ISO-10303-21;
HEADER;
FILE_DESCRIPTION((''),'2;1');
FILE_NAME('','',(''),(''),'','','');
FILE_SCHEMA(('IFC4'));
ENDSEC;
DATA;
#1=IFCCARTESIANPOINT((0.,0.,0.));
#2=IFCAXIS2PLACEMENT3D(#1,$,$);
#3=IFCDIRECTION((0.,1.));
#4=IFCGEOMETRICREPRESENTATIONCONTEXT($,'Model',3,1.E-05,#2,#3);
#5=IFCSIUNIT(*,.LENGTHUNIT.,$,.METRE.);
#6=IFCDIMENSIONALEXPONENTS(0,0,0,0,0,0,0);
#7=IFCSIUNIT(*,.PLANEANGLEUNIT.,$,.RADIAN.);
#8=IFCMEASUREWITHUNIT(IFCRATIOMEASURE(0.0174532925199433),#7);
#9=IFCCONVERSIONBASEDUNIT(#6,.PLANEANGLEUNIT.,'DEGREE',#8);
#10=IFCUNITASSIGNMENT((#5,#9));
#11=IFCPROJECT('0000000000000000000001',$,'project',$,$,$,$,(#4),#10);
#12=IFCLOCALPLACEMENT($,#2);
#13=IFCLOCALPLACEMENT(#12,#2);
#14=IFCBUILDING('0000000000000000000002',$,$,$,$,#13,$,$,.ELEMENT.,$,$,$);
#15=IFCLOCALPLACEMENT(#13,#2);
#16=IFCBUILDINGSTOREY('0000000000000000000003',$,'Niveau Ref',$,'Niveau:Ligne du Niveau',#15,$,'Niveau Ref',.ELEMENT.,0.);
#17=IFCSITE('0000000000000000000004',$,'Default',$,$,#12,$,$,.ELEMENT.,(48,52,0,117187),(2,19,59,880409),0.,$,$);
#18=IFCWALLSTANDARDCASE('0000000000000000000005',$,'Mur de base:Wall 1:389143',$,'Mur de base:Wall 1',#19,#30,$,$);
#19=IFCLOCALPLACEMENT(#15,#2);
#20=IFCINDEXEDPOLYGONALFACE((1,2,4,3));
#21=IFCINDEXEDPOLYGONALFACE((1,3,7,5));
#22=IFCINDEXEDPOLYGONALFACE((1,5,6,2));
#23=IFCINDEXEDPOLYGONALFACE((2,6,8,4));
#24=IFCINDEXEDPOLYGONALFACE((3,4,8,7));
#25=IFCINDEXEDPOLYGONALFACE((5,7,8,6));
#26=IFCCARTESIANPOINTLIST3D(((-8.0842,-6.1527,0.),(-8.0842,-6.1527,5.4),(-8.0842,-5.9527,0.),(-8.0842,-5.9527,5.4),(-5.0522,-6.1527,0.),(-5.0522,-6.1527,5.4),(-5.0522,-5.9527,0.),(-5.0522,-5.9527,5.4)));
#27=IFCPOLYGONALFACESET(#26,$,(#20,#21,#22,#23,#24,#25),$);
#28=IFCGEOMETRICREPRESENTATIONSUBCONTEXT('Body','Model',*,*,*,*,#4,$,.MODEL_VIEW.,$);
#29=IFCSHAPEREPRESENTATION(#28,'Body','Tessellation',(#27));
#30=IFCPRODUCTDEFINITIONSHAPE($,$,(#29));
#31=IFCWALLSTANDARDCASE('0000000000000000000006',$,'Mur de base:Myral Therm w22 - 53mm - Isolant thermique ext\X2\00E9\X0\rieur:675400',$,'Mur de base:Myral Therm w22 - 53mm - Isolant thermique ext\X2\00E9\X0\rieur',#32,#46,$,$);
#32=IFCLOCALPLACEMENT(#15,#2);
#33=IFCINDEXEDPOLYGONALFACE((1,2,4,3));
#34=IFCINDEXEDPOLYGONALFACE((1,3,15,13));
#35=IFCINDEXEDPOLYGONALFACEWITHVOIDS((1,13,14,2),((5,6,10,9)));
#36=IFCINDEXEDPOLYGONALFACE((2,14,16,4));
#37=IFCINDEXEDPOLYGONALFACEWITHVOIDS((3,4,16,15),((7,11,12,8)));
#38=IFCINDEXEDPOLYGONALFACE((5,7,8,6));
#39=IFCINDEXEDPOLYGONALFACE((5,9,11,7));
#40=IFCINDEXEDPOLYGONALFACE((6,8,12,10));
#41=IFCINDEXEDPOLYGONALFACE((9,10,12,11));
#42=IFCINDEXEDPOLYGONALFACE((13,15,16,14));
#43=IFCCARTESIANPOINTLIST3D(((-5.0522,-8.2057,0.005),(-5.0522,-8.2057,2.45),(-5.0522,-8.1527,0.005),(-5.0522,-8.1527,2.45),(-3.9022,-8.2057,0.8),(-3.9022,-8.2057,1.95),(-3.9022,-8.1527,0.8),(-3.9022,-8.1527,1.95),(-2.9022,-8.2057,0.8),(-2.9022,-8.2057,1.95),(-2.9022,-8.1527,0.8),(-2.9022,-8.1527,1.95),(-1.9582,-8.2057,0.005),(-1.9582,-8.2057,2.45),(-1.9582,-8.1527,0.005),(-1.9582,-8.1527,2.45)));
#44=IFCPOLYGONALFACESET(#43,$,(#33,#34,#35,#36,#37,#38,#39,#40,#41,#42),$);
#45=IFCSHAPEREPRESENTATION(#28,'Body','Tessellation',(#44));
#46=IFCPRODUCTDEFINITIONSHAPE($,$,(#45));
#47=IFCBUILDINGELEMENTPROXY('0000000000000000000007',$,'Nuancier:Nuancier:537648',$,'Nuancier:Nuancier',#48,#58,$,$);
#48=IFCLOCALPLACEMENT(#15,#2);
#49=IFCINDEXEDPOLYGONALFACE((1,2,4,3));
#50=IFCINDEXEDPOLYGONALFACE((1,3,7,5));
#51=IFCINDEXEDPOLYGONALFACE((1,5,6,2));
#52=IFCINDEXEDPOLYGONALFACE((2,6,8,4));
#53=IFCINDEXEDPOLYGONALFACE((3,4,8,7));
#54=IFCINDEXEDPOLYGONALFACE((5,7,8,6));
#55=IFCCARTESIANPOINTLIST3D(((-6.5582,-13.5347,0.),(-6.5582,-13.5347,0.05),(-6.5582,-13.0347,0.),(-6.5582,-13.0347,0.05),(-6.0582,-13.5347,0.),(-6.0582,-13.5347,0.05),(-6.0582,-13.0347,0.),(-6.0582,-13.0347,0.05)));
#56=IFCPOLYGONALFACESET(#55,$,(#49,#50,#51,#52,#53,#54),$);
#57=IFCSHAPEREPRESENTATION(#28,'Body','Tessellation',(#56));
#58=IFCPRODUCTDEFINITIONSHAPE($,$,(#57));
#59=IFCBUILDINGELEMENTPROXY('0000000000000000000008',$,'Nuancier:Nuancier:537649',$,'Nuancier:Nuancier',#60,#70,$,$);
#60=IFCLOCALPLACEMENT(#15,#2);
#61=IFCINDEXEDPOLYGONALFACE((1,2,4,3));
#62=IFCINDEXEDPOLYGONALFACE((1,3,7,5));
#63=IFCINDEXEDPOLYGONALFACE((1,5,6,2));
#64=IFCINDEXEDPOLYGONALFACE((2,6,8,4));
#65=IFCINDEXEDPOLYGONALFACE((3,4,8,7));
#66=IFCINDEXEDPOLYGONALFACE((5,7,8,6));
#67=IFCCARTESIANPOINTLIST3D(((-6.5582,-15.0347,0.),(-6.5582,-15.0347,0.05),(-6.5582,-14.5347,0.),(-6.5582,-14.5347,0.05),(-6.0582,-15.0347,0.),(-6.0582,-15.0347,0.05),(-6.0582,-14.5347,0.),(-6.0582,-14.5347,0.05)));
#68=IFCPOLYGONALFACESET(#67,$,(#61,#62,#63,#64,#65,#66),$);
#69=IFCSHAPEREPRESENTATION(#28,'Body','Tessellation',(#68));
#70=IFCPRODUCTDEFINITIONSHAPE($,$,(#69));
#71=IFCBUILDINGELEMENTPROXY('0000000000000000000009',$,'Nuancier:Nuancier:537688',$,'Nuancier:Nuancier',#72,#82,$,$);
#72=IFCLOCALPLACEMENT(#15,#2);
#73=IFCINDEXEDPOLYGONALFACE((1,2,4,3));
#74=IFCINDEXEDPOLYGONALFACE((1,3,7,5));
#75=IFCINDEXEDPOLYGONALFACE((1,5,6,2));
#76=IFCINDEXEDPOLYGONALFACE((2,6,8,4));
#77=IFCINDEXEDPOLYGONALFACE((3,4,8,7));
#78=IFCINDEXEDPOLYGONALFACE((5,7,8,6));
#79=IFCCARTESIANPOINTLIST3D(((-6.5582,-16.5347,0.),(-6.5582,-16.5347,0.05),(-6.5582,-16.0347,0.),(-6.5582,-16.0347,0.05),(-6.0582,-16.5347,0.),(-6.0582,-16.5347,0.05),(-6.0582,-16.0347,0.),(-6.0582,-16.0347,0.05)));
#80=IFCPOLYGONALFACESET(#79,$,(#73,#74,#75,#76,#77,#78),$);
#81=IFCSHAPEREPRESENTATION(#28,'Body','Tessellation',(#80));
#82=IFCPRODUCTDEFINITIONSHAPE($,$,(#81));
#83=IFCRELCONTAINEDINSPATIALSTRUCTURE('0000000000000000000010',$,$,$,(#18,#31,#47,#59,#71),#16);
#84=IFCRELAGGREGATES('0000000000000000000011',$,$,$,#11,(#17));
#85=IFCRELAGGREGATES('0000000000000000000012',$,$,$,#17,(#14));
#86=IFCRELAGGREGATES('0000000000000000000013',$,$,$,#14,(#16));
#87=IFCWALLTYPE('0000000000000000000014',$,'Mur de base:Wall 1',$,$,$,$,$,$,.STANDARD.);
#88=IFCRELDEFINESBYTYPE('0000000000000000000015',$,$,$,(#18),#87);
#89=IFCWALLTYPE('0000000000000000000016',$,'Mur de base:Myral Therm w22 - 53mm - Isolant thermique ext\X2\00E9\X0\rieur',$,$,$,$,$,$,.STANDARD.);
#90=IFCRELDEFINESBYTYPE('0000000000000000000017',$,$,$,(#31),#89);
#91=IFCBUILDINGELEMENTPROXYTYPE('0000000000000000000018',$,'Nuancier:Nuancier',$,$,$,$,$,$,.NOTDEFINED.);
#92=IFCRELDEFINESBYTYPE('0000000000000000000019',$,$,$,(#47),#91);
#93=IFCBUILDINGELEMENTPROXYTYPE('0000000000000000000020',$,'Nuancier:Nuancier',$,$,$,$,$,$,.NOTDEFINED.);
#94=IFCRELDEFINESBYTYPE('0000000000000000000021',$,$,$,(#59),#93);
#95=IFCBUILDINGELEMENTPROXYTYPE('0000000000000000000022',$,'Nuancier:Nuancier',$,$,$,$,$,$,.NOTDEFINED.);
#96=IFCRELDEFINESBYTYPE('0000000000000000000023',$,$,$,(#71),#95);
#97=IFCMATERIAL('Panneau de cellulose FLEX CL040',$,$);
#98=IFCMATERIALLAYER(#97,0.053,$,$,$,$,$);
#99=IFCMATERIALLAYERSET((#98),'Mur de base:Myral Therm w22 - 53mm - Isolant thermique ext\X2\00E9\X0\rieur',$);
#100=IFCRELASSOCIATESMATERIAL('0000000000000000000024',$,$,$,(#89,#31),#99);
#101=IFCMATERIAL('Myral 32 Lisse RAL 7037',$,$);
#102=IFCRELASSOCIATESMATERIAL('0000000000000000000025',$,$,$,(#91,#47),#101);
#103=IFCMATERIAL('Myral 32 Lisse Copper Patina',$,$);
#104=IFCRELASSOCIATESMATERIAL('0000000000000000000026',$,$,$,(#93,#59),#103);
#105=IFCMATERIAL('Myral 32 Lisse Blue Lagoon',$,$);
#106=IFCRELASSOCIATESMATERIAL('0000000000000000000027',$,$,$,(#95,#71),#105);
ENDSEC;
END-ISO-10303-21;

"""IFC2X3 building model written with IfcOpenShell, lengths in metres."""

from ifc_helpers import new_model, entity, si_unit, converted_unit, direction, frame, frame_2d, origin, origin_2d_with_axis, place, context, subcontext, project, spatial, rectangle, extrude, source, transform, mapped, material, layer, layer_set, layer_usage, type_object, type_shapes, element, save


model = new_model("IFC2X3")

# Units and contexts
model_context = context("Model", 3, precision=1e-05, world=origin(), true_north=direction((0.0, 1.0)))
body_context = subcontext(model_context, "Body", "Model", "MODEL_VIEW")
ifc_project = project(units=[si_unit("LENGTHUNIT", "METRE"), converted_unit("PLANEANGLEUNIT", "DEGREE", entity("IfcRatioMeasure", 0.0174532925199433), si_unit("PLANEANGLEUNIT", "RADIAN"), dimensions=[0, 0, 0, 0, 0, 0, 0])], contexts=[model_context])

# Site, building, storey
site_placement = place(None, origin())
site = spatial("IfcSite", under=ifc_project, at=site_placement, Name="Default", CompositionType="ELEMENT", RefLatitude=(48, 52, 0, 117187), RefLongitude=(2, 19, 59, 880409), RefElevation=0.0)
building_placement = place(site_placement, origin())
building = spatial("IfcBuilding", under=site, at=building_placement, CompositionType="ELEMENT")
storey_placement = place(building_placement, origin())
storey = spatial("IfcBuildingStorey", under=building, at=storey_placement, Name="Niveau Ref", ObjectType="Niveau:Ligne du Niveau", LongName="Niveau Ref", CompositionType="ELEMENT", Elevation=0.0)

# Wall
wall_type_1 = type_object("IfcWallType", Name="Mur de base:Wall 1", PredefinedType="STANDARD")
wall_1_placement = place(storey_placement, frame((-5.0522, -6.0527, 0.0), z_axis=(0.0, 0.0, 1.0), x_axis=(-1.0, 0.0, 0.0)))
element("IfcWallStandardCase", 1, at=wall_1_placement, inside=storey, type_object=wall_type_1, Name="Mur de base:Wall 1:389143", ObjectType="Mur de base:Wall 1", context=body_context, shape_type="SweptSolid", body=[
    extrude(rectangle(XDim=3.032, YDim=0.2, at=frame_2d((1.516, 0.0), x_axis=(-1.0, 0.0))), origin(), (0.0, 0.0, 1.0), 5.4),
])

# Wall, opening
ifc_material_1 = material(Name="Panneau de cellulose FLEX CL040")
ifc_layer = layer(ifc_material_1, 0.053)
ifc_layer_set = layer_set([ifc_layer], Name="Mur de base:Myral Therm w22 - 53mm - Isolant thermique extérieur")
ifc_layer_usage = layer_usage(ifc_layer_set, "AXIS2", "NEGATIVE", 0.0265)
wall_type_2 = type_object("IfcWallType", Name="Mur de base:Myral Therm w22 - 53mm - Isolant thermique extérieur", PredefinedType="STANDARD", material=ifc_layer_set)
wall_2_placement = place(storey_placement, frame((-5.0522, -8.1792, 0.005)))
wall_2 = element("IfcWallStandardCase", 2, at=wall_2_placement, inside=storey, type_object=wall_type_2, material=ifc_layer_usage, Name="Mur de base:Myral Therm w22 - 53mm - Isolant thermique extérieur:675400", ObjectType="Mur de base:Myral Therm w22 - 53mm - Isolant thermique extérieur", context=body_context, shape_type="SweptSolid", body=[
    extrude(rectangle(XDim=3.094, YDim=0.053, at=frame_2d((1.547, 0.0), x_axis=(-1.0, 0.0))), origin(), (0.0, 0.0, 1.0), 2.445),
])
opening_placement = place(wall_2_placement, origin())
element("IfcOpeningElement", 3, at=opening_placement, cuts=wall_2, ObjectType="Opening", context=body_context, shape_type="SweptSolid", body=[
    extrude(rectangle(XDim=1.15, YDim=1.0, at=frame_2d((0.0, 0.0), x_axis=(0.0, 1.0))), frame((1.65, 0.0265, 1.37), z_axis=(0.0, -1.0, 0.0), x_axis=(-1.0, 0.0, 0.0)), (0.0, 0.0, 1.0), 0.053),
])

# Building element proxies
ifc_material_2 = material(Name="Myral 32 Lisse RAL 7037")
building_element_proxy_type_1 = type_object("IfcBuildingElementProxyType", Name="Nuancier:Nuancier", PredefinedType="NOTDEFINED", material=ifc_material_2)
shared_shape_1 = source(origin(), body_context, "Body", "SweptSolid", [
    extrude(rectangle(XDim=0.5, YDim=0.5, at=origin_2d_with_axis()), frame((0.0, 0.0, 0.0), z_axis=(0.0, 0.0, 1.0), x_axis=(-1.0, 0.0, 0.0)), (0.0, 0.0, 1.0), 0.05),
])
type_shapes(building_element_proxy_type_1, [shared_shape_1])
proxy_1_placement = place(storey_placement, frame((-6.3082, -13.2847, 0.0)))
element("IfcBuildingElementProxy", 4, at=proxy_1_placement, inside=storey, type_object=building_element_proxy_type_1, material=ifc_material_2, Name="Nuancier:Nuancier:537648", ObjectType="Nuancier:Nuancier", context=body_context, shape_type="MappedRepresentation", body=[
    mapped(shared_shape_1, transform((0.0, 0.0, 0.0), scale=1.0)),
])
ifc_material_3 = material(Name="Myral 32 Lisse Copper Patina")
building_element_proxy_type_2 = type_object("IfcBuildingElementProxyType", Name="Nuancier:Nuancier", PredefinedType="NOTDEFINED", material=ifc_material_3)
shared_shape_2 = source(origin(), body_context, "Body", "SweptSolid", [
    extrude(rectangle(XDim=0.5, YDim=0.5, at=origin_2d_with_axis()), frame((0.0, 0.0, 0.0), z_axis=(0.0, 0.0, 1.0), x_axis=(-1.0, 0.0, 0.0)), (0.0, 0.0, 1.0), 0.05),
])
type_shapes(building_element_proxy_type_2, [shared_shape_2])
proxy_2_placement = place(storey_placement, frame((-6.3082, -14.7847, 0.0)))
element("IfcBuildingElementProxy", 5, at=proxy_2_placement, inside=storey, type_object=building_element_proxy_type_2, material=ifc_material_3, Name="Nuancier:Nuancier:537649", ObjectType="Nuancier:Nuancier", context=body_context, shape_type="MappedRepresentation", body=[
    mapped(shared_shape_2, transform((0.0, 0.0, 0.0), scale=1.0)),
])
ifc_material_4 = material(Name="Myral 32 Lisse Blue Lagoon")
building_element_proxy_type_3 = type_object("IfcBuildingElementProxyType", Name="Nuancier:Nuancier", PredefinedType="NOTDEFINED", material=ifc_material_4)
shared_shape_3 = source(origin(), body_context, "Body", "SweptSolid", [
    extrude(rectangle(XDim=0.5, YDim=0.5, at=origin_2d_with_axis()), frame((0.0, 0.0, 0.0), z_axis=(0.0, 0.0, 1.0), x_axis=(-1.0, 0.0, 0.0)), (0.0, 0.0, 1.0), 0.05),
])
type_shapes(building_element_proxy_type_3, [shared_shape_3])
proxy_3_placement = place(storey_placement, frame((-6.3082, -16.2847, 0.0)))
element("IfcBuildingElementProxy", 6, at=proxy_3_placement, inside=storey, type_object=building_element_proxy_type_3, material=ifc_material_4, Name="Nuancier:Nuancier:537688", ObjectType="Nuancier:Nuancier", context=body_context, shape_type="MappedRepresentation", body=[
    mapped(shared_shape_3, transform((0.0, 0.0, 0.0), scale=1.0)),
])

save(model, "model.ifc")
